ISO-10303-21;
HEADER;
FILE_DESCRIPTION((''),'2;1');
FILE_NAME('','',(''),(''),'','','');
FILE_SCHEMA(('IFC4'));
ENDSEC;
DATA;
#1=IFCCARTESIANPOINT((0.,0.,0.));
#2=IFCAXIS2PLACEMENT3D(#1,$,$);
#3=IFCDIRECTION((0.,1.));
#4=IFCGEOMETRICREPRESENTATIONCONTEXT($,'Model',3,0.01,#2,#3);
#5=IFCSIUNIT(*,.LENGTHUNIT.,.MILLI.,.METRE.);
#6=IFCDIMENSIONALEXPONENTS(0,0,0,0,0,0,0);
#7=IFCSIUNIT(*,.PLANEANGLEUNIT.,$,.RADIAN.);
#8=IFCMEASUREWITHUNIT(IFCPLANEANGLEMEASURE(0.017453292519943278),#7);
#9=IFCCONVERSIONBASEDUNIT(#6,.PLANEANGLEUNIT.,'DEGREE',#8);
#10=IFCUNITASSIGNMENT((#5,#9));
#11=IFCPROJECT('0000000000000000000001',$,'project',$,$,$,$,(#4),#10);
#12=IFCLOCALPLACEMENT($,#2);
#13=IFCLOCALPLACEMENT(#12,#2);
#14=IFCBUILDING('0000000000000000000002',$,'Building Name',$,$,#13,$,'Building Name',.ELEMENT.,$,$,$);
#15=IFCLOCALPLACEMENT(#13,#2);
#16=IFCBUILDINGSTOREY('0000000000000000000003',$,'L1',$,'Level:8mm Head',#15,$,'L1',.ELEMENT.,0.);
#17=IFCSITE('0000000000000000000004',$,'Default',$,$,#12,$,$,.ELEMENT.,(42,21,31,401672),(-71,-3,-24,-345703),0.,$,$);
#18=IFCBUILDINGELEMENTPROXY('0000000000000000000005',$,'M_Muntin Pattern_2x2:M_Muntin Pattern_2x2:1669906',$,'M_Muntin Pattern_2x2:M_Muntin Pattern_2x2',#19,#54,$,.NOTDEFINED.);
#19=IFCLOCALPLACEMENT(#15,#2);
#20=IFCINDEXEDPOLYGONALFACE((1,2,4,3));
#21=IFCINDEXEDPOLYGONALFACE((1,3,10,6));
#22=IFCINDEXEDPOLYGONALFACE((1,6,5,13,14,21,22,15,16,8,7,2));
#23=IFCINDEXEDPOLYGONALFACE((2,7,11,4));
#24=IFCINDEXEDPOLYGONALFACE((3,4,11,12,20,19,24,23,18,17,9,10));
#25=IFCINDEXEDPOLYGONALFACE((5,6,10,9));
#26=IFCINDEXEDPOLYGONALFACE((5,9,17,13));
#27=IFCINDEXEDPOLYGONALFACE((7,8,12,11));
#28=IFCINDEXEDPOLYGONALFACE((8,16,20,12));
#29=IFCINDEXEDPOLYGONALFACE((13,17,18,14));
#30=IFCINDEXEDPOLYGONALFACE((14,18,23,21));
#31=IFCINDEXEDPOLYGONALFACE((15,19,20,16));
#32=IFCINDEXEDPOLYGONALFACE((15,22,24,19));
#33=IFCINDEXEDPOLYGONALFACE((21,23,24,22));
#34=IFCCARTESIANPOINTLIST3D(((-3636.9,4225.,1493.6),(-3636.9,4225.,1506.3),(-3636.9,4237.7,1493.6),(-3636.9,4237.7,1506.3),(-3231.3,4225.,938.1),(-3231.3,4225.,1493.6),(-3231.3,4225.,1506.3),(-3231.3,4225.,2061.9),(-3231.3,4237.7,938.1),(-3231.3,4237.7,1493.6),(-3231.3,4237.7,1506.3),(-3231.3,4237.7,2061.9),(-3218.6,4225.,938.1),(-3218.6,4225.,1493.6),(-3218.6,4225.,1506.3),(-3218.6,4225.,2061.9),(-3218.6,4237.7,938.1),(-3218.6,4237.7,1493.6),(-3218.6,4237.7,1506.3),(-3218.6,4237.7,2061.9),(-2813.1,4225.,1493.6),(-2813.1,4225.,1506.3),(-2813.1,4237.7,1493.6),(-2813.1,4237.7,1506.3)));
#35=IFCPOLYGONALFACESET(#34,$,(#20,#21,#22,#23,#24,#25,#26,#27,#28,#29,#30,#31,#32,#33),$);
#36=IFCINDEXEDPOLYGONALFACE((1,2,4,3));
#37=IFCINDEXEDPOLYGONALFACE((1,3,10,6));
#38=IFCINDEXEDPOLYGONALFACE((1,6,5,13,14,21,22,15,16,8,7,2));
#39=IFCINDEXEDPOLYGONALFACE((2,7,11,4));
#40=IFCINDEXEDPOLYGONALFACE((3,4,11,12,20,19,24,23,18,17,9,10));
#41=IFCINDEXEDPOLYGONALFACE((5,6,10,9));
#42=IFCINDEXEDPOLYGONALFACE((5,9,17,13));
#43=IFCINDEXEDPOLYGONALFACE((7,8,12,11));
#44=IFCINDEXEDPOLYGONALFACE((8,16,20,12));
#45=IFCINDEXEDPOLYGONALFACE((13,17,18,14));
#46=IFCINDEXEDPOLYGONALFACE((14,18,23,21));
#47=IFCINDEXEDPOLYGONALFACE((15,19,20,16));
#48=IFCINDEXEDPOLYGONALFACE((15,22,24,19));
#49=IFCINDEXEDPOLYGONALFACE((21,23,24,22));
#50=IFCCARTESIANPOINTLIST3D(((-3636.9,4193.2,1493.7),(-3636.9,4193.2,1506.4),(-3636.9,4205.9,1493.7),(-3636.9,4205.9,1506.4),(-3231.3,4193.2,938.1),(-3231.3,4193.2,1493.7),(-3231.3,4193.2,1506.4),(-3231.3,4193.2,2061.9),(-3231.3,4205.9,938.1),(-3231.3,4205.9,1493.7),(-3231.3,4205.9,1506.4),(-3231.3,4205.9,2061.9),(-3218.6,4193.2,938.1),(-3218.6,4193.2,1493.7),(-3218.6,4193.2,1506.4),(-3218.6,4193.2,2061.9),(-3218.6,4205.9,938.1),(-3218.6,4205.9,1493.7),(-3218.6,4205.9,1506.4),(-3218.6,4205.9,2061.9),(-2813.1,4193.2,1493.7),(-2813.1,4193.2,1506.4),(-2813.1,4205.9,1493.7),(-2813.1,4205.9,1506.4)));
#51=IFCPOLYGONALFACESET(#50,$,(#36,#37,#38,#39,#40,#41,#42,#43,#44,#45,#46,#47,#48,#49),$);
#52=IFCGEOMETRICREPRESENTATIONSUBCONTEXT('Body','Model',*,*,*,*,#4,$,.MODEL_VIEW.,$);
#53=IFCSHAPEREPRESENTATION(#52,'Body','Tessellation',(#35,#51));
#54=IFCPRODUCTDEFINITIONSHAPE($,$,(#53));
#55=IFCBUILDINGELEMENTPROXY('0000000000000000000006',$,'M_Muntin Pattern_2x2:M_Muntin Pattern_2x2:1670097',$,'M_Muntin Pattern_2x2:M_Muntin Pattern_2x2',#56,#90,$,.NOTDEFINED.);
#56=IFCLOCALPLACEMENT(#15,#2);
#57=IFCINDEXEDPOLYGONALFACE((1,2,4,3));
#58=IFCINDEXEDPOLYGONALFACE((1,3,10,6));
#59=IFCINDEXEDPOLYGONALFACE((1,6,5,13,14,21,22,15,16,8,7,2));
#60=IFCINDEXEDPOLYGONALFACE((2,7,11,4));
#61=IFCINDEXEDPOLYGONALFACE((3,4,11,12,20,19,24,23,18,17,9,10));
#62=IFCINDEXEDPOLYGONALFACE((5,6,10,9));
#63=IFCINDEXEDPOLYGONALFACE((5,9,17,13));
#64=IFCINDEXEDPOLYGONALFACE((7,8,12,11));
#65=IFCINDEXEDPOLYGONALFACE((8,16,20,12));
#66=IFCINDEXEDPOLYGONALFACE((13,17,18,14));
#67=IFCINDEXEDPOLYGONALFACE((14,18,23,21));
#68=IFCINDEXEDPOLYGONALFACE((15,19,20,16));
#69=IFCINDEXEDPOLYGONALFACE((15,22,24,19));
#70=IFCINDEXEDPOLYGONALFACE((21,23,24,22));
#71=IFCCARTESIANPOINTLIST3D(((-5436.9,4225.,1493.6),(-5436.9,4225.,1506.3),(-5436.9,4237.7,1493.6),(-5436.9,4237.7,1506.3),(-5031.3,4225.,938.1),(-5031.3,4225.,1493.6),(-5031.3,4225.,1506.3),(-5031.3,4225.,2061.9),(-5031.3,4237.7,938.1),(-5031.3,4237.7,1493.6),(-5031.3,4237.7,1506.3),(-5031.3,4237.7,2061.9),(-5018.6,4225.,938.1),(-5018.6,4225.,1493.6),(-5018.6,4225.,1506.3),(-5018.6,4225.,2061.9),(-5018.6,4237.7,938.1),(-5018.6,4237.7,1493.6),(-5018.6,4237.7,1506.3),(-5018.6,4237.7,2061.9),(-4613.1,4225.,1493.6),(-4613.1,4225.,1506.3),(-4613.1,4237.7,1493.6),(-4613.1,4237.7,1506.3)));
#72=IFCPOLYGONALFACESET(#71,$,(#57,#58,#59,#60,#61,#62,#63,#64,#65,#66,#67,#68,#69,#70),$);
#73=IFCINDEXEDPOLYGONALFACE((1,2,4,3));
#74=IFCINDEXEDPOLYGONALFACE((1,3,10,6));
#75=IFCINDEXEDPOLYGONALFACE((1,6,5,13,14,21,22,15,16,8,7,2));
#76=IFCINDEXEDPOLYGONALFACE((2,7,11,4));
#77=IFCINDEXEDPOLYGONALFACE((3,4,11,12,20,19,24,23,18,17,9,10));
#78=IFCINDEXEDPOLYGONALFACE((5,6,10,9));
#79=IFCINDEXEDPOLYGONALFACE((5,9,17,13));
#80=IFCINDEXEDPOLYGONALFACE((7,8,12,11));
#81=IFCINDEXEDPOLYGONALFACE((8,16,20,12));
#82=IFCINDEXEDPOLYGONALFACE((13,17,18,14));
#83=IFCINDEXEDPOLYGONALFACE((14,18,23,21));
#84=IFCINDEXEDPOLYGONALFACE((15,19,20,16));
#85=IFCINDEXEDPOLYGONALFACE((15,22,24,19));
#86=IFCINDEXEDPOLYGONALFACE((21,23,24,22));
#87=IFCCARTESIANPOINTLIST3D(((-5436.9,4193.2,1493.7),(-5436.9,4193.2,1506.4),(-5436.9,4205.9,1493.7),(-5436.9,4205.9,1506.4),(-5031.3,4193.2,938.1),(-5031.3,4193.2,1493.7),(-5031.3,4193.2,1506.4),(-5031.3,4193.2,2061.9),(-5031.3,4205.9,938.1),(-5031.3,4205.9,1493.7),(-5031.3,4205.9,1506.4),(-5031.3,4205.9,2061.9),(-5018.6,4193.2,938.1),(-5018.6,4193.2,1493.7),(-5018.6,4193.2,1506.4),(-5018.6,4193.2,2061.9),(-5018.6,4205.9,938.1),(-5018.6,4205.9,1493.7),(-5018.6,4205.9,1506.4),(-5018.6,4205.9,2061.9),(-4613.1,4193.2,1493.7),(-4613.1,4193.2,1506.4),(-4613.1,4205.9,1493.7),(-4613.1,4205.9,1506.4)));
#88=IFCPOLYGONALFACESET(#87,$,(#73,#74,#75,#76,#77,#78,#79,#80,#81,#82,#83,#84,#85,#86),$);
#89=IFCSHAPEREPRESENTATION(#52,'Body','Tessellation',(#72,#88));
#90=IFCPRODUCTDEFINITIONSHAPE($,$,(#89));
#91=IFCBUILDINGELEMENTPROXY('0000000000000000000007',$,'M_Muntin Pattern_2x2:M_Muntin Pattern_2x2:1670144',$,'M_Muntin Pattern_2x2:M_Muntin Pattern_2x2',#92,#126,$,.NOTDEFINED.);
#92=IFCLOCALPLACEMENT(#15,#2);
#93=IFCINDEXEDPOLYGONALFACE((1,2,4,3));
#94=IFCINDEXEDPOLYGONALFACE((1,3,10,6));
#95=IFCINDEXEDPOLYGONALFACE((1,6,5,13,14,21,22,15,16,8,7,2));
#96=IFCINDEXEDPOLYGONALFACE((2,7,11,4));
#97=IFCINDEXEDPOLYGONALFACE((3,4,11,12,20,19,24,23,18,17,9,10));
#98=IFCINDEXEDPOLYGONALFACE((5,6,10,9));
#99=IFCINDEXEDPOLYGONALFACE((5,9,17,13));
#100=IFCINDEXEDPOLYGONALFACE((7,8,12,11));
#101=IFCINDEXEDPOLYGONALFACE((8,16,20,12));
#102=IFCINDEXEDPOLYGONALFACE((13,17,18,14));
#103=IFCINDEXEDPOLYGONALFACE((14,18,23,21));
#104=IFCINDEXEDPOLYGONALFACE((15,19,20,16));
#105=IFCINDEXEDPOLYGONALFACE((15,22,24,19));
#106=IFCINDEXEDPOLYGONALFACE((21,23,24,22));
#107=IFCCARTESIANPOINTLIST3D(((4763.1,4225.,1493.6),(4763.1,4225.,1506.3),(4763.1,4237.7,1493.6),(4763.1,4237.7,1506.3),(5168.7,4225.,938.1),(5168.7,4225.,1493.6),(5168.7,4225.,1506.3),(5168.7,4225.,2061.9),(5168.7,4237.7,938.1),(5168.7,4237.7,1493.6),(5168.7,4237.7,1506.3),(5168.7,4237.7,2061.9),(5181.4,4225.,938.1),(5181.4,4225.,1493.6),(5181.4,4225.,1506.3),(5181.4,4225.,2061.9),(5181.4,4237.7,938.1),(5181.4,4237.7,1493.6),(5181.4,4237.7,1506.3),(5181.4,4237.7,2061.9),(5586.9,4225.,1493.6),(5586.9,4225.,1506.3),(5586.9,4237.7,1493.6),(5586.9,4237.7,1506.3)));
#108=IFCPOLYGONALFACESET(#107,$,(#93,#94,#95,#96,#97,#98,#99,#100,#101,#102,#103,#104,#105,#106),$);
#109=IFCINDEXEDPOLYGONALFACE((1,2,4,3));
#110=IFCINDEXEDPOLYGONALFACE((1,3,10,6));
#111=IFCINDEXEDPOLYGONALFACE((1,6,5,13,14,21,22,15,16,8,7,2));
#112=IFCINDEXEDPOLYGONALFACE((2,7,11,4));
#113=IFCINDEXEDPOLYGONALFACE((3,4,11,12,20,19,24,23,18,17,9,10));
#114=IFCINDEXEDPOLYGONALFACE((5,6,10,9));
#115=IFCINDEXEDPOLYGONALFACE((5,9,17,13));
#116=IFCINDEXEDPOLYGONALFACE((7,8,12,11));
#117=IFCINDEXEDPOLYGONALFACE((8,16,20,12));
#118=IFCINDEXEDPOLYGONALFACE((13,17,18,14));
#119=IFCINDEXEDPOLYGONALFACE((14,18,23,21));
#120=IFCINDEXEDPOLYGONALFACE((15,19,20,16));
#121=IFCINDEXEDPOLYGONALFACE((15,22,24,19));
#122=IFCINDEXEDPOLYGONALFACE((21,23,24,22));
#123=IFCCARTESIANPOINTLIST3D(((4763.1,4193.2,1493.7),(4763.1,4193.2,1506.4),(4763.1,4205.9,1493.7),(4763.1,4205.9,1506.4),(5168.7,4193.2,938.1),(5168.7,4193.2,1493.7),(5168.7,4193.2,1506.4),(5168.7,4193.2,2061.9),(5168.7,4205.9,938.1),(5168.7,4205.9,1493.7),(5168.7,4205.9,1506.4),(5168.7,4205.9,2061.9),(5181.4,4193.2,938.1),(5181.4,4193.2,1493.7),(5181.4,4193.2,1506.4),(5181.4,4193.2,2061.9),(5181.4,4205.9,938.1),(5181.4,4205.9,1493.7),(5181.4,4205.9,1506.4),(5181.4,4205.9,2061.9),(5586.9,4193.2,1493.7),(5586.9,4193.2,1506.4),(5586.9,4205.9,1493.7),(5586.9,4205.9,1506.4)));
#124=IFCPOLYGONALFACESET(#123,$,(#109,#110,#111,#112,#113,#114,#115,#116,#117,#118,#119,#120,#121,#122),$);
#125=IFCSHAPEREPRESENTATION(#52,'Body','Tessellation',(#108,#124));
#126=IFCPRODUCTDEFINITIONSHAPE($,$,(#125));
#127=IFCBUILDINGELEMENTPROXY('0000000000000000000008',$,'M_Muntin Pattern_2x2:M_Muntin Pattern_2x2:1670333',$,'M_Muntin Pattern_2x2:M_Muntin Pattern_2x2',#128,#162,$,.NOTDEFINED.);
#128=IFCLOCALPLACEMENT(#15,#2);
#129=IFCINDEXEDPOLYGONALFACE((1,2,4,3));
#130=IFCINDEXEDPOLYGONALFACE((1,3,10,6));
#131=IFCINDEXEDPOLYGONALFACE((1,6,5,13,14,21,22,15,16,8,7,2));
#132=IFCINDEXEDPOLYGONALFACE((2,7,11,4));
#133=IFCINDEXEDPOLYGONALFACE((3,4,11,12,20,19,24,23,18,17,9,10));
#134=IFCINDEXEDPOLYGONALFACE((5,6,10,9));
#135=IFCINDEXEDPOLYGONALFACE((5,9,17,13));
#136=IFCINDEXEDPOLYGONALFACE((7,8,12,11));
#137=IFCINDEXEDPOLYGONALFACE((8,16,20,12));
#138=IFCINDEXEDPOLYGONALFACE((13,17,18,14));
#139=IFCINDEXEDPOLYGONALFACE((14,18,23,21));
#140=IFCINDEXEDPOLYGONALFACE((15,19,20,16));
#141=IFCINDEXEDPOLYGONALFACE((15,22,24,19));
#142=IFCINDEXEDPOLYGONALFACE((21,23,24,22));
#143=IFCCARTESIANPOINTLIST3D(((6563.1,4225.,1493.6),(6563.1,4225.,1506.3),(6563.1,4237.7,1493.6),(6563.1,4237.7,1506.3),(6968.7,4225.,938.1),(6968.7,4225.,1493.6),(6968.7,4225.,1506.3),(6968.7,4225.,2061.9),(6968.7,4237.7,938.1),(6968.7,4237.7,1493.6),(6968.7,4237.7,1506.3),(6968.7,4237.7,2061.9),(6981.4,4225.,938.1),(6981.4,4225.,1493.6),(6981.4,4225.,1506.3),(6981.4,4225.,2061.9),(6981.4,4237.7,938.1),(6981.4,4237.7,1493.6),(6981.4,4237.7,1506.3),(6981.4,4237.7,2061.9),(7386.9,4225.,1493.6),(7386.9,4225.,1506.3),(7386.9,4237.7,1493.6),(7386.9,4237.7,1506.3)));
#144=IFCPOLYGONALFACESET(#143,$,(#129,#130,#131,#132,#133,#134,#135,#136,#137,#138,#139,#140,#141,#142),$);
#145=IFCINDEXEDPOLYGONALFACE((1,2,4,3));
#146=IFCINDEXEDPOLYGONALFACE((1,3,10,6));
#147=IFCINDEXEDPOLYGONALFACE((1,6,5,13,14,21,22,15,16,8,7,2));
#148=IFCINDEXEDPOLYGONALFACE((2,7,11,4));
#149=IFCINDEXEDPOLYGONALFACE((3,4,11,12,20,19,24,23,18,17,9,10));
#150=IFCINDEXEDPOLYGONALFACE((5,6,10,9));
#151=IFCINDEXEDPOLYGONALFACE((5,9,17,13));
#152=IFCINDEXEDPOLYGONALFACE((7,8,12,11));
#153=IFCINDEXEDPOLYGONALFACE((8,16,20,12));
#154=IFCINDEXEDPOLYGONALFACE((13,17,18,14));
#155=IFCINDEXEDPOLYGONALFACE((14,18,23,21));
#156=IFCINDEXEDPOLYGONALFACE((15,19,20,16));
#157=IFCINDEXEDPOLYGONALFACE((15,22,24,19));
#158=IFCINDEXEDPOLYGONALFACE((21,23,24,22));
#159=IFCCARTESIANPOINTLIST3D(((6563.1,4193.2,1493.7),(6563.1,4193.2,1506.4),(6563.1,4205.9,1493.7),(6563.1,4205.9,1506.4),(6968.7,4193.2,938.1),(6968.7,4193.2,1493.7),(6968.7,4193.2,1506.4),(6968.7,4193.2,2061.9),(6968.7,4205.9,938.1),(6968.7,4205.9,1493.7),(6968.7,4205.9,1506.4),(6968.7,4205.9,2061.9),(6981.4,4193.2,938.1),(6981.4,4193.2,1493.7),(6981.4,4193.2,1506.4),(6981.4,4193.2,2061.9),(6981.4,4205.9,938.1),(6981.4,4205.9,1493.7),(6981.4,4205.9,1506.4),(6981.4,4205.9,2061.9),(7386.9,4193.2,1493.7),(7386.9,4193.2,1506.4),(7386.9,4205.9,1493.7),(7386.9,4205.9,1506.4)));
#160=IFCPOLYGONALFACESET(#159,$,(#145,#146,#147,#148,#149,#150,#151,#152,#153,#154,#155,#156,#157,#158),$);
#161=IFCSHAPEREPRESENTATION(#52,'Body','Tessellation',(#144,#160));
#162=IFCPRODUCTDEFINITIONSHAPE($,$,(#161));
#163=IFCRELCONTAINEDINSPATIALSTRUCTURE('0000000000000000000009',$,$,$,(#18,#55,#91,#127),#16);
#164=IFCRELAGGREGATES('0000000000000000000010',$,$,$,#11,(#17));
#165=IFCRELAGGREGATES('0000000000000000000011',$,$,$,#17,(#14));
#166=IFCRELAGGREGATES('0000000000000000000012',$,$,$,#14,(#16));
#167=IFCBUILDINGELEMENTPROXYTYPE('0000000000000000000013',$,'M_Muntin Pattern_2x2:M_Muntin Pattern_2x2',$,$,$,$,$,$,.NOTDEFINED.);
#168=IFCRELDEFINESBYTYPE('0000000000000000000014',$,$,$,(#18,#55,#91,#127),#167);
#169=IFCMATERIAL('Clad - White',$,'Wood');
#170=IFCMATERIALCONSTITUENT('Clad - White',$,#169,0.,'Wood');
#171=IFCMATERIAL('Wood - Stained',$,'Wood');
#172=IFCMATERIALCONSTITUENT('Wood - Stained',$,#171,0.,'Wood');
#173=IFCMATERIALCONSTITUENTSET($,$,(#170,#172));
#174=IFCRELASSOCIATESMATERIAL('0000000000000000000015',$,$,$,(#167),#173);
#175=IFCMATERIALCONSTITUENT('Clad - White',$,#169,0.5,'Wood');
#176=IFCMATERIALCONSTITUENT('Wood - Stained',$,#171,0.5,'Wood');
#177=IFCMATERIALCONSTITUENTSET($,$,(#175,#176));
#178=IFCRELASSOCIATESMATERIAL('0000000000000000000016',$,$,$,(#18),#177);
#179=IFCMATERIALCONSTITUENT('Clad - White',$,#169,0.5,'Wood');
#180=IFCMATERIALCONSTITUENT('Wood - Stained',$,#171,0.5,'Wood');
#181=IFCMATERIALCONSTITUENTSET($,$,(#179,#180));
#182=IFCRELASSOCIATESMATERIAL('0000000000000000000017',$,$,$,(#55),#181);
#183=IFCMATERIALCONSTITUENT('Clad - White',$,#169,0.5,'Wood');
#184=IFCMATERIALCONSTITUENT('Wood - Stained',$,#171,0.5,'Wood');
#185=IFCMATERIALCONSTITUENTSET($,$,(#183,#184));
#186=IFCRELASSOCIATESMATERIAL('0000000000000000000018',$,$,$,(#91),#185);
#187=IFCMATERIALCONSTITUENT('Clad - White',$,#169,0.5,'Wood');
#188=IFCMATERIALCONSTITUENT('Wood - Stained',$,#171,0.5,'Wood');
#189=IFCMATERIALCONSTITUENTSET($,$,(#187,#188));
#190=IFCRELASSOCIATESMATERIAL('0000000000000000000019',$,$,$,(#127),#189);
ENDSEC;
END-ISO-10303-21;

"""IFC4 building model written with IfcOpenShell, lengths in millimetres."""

from ifc_helpers import new_model, entity, si_unit, converted_unit, direction, frame, origin, place, context, subcontext, project, spatial, polyline, outline, extrude, source, transform, mapped, material, constituent, constituent_set, type_object, type_shapes, element, save


model = new_model("IFC4")

# Units and contexts
model_context = context("Model", 3, precision=0.01, world=origin(), true_north=direction((0.0, 1.0)))
body_context = subcontext(model_context, "Body", "Model", "MODEL_VIEW")
ifc_project = project(units=[si_unit("LENGTHUNIT", "METRE", prefix="MILLI"), converted_unit("PLANEANGLEUNIT", "DEGREE", entity("IfcPlaneAngleMeasure", 0.017453292519943278), si_unit("PLANEANGLEUNIT", "RADIAN"), dimensions=[0, 0, 0, 0, 0, 0, 0])], contexts=[model_context])

# Site, building, storey
site_placement = place(None, origin())
site = spatial("IfcSite", under=ifc_project, at=site_placement, Name="Default", CompositionType="ELEMENT", RefLatitude=(42, 21, 31, 401672), RefLongitude=(-71, -3, -24, -345703), RefElevation=0.0)
building_placement = place(site_placement, origin())
building = spatial("IfcBuilding", under=site, at=building_placement, Name="Building Name", LongName="Building Name", CompositionType="ELEMENT")
storey_placement = place(building_placement, origin())
storey = spatial("IfcBuildingStorey", under=building, at=storey_placement, Name="L1", ObjectType="Level:8mm Head", LongName="L1", CompositionType="ELEMENT", Elevation=0.0)

# Building element proxies
ifc_material_1 = material(Name="Clad - White", Category="Wood")
ifc_material_2 = material(Name="Wood - Stained", Category="Wood")
ifc_constituent_1 = constituent(ifc_material_1, Name="Clad - White", Category="Wood", fraction=0.0)
ifc_constituent_2 = constituent(ifc_material_2, Name="Wood - Stained", Category="Wood", fraction=0.0)
ifc_constituent_set_1 = constituent_set(constituents=[ifc_constituent_1, ifc_constituent_2])
building_element_proxy_type_1 = type_object("IfcBuildingElementProxyType", Name="M_Muntin Pattern_2x2:M_Muntin Pattern_2x2", PredefinedType="NOTDEFINED", material=ifc_constituent_set_1)
shared_shape_1 = source(origin(), body_context, "Body", "SweptSolid", [
    extrude(outline(polyline([(6.4, -6.4), (561.9, -6.4), (561.9, 6.3), (6.4, 6.3), (6.4, 411.9), (-6.3, 411.9), (-6.3, 6.3), (-561.9, 6.3), (-561.9, -6.4), (-6.3, -6.4), (-6.3, -411.9), (6.4, -411.9), (6.4, -6.4)])), frame((0.0, -22.2, 561.9), z_axis=(0.0, 1.0, 0.0), x_axis=(0.0, 0.0, 1.0)), (0.0, 0.0, 1.0), 12.7),
    extrude(outline(polyline([(6.4, -6.4), (561.9, -6.4), (561.9, 6.3), (6.4, 6.3), (6.4, 411.9), (-6.3, 411.9), (-6.3, 6.3), (-561.9, 6.3), (-561.9, -6.4), (-6.3, -6.4), (-6.3, -411.9), (6.4, -411.9), (6.4, -6.4)])), frame((0.0, 9.5, 561.9), z_axis=(0.0, 1.0, 0.0), x_axis=(0.0, 0.0, 1.0)), (0.0, 0.0, 1.0), 12.7),
])
type_shapes(building_element_proxy_type_1, [shared_shape_1])
ifc_constituent_3 = constituent(ifc_material_1, Name="Clad - White", Category="Wood", fraction=0.5)
ifc_constituent_4 = constituent(ifc_material_2, Name="Wood - Stained", Category="Wood", fraction=0.5)
ifc_constituent_set_2 = constituent_set(constituents=[ifc_constituent_3, ifc_constituent_4])
proxy_1_placement = place(storey_placement, frame((-3225.0, 4215.5, 938.1), z_axis=(0.0, 0.0, 1.0), x_axis=(-1.0, 0.0, 0.0)))
element("IfcBuildingElementProxy", 1, at=proxy_1_placement, inside=storey, type_object=building_element_proxy_type_1, material=ifc_constituent_set_2, Name="M_Muntin Pattern_2x2:M_Muntin Pattern_2x2:1669906", ObjectType="M_Muntin Pattern_2x2:M_Muntin Pattern_2x2", PredefinedType="NOTDEFINED", context=body_context, shape_type="MappedRepresentation", body=[
    mapped(shared_shape_1, transform((0.0, 0.0, 0.0), scale=1.0)),
])
ifc_constituent_5 = constituent(ifc_material_1, Name="Clad - White", Category="Wood", fraction=0.5)
ifc_constituent_6 = constituent(ifc_material_2, Name="Wood - Stained", Category="Wood", fraction=0.5)
ifc_constituent_set_3 = constituent_set(constituents=[ifc_constituent_5, ifc_constituent_6])
proxy_2_placement = place(storey_placement, frame((-5025.0, 4215.5, 938.1), z_axis=(0.0, 0.0, 1.0), x_axis=(-1.0, 0.0, 0.0)))
element("IfcBuildingElementProxy", 2, at=proxy_2_placement, inside=storey, type_object=building_element_proxy_type_1, material=ifc_constituent_set_3, Name="M_Muntin Pattern_2x2:M_Muntin Pattern_2x2:1670097", ObjectType="M_Muntin Pattern_2x2:M_Muntin Pattern_2x2", PredefinedType="NOTDEFINED", context=body_context, shape_type="MappedRepresentation", body=[
    mapped(shared_shape_1, transform((0.0, 0.0, 0.0), scale=1.0)),
])
ifc_constituent_7 = constituent(ifc_material_1, Name="Clad - White", Category="Wood", fraction=0.5)
ifc_constituent_8 = constituent(ifc_material_2, Name="Wood - Stained", Category="Wood", fraction=0.5)
ifc_constituent_set_4 = constituent_set(constituents=[ifc_constituent_7, ifc_constituent_8])
proxy_3_placement = place(storey_placement, frame((5175.0, 4215.5, 938.1), z_axis=(0.0, 0.0, 1.0), x_axis=(-1.0, 0.0, 0.0)))
element("IfcBuildingElementProxy", 3, at=proxy_3_placement, inside=storey, type_object=building_element_proxy_type_1, material=ifc_constituent_set_4, Name="M_Muntin Pattern_2x2:M_Muntin Pattern_2x2:1670144", ObjectType="M_Muntin Pattern_2x2:M_Muntin Pattern_2x2", PredefinedType="NOTDEFINED", context=body_context, shape_type="MappedRepresentation", body=[
    mapped(shared_shape_1, transform((0.0, 0.0, 0.0), scale=1.0)),
])
ifc_constituent_9 = constituent(ifc_material_1, Name="Clad - White", Category="Wood", fraction=0.5)
ifc_constituent_10 = constituent(ifc_material_2, Name="Wood - Stained", Category="Wood", fraction=0.5)
ifc_constituent_set_5 = constituent_set(constituents=[ifc_constituent_9, ifc_constituent_10])
proxy_4_placement = place(storey_placement, frame((6975.0, 4215.5, 938.1), z_axis=(0.0, 0.0, 1.0), x_axis=(-1.0, 0.0, 0.0)))
element("IfcBuildingElementProxy", 4, at=proxy_4_placement, inside=storey, type_object=building_element_proxy_type_1, material=ifc_constituent_set_5, Name="M_Muntin Pattern_2x2:M_Muntin Pattern_2x2:1670333", ObjectType="M_Muntin Pattern_2x2:M_Muntin Pattern_2x2", PredefinedType="NOTDEFINED", context=body_context, shape_type="MappedRepresentation", body=[
    mapped(shared_shape_1, transform((0.0, 0.0, 0.0), scale=1.0)),
])

save(model, "model.ifc")
